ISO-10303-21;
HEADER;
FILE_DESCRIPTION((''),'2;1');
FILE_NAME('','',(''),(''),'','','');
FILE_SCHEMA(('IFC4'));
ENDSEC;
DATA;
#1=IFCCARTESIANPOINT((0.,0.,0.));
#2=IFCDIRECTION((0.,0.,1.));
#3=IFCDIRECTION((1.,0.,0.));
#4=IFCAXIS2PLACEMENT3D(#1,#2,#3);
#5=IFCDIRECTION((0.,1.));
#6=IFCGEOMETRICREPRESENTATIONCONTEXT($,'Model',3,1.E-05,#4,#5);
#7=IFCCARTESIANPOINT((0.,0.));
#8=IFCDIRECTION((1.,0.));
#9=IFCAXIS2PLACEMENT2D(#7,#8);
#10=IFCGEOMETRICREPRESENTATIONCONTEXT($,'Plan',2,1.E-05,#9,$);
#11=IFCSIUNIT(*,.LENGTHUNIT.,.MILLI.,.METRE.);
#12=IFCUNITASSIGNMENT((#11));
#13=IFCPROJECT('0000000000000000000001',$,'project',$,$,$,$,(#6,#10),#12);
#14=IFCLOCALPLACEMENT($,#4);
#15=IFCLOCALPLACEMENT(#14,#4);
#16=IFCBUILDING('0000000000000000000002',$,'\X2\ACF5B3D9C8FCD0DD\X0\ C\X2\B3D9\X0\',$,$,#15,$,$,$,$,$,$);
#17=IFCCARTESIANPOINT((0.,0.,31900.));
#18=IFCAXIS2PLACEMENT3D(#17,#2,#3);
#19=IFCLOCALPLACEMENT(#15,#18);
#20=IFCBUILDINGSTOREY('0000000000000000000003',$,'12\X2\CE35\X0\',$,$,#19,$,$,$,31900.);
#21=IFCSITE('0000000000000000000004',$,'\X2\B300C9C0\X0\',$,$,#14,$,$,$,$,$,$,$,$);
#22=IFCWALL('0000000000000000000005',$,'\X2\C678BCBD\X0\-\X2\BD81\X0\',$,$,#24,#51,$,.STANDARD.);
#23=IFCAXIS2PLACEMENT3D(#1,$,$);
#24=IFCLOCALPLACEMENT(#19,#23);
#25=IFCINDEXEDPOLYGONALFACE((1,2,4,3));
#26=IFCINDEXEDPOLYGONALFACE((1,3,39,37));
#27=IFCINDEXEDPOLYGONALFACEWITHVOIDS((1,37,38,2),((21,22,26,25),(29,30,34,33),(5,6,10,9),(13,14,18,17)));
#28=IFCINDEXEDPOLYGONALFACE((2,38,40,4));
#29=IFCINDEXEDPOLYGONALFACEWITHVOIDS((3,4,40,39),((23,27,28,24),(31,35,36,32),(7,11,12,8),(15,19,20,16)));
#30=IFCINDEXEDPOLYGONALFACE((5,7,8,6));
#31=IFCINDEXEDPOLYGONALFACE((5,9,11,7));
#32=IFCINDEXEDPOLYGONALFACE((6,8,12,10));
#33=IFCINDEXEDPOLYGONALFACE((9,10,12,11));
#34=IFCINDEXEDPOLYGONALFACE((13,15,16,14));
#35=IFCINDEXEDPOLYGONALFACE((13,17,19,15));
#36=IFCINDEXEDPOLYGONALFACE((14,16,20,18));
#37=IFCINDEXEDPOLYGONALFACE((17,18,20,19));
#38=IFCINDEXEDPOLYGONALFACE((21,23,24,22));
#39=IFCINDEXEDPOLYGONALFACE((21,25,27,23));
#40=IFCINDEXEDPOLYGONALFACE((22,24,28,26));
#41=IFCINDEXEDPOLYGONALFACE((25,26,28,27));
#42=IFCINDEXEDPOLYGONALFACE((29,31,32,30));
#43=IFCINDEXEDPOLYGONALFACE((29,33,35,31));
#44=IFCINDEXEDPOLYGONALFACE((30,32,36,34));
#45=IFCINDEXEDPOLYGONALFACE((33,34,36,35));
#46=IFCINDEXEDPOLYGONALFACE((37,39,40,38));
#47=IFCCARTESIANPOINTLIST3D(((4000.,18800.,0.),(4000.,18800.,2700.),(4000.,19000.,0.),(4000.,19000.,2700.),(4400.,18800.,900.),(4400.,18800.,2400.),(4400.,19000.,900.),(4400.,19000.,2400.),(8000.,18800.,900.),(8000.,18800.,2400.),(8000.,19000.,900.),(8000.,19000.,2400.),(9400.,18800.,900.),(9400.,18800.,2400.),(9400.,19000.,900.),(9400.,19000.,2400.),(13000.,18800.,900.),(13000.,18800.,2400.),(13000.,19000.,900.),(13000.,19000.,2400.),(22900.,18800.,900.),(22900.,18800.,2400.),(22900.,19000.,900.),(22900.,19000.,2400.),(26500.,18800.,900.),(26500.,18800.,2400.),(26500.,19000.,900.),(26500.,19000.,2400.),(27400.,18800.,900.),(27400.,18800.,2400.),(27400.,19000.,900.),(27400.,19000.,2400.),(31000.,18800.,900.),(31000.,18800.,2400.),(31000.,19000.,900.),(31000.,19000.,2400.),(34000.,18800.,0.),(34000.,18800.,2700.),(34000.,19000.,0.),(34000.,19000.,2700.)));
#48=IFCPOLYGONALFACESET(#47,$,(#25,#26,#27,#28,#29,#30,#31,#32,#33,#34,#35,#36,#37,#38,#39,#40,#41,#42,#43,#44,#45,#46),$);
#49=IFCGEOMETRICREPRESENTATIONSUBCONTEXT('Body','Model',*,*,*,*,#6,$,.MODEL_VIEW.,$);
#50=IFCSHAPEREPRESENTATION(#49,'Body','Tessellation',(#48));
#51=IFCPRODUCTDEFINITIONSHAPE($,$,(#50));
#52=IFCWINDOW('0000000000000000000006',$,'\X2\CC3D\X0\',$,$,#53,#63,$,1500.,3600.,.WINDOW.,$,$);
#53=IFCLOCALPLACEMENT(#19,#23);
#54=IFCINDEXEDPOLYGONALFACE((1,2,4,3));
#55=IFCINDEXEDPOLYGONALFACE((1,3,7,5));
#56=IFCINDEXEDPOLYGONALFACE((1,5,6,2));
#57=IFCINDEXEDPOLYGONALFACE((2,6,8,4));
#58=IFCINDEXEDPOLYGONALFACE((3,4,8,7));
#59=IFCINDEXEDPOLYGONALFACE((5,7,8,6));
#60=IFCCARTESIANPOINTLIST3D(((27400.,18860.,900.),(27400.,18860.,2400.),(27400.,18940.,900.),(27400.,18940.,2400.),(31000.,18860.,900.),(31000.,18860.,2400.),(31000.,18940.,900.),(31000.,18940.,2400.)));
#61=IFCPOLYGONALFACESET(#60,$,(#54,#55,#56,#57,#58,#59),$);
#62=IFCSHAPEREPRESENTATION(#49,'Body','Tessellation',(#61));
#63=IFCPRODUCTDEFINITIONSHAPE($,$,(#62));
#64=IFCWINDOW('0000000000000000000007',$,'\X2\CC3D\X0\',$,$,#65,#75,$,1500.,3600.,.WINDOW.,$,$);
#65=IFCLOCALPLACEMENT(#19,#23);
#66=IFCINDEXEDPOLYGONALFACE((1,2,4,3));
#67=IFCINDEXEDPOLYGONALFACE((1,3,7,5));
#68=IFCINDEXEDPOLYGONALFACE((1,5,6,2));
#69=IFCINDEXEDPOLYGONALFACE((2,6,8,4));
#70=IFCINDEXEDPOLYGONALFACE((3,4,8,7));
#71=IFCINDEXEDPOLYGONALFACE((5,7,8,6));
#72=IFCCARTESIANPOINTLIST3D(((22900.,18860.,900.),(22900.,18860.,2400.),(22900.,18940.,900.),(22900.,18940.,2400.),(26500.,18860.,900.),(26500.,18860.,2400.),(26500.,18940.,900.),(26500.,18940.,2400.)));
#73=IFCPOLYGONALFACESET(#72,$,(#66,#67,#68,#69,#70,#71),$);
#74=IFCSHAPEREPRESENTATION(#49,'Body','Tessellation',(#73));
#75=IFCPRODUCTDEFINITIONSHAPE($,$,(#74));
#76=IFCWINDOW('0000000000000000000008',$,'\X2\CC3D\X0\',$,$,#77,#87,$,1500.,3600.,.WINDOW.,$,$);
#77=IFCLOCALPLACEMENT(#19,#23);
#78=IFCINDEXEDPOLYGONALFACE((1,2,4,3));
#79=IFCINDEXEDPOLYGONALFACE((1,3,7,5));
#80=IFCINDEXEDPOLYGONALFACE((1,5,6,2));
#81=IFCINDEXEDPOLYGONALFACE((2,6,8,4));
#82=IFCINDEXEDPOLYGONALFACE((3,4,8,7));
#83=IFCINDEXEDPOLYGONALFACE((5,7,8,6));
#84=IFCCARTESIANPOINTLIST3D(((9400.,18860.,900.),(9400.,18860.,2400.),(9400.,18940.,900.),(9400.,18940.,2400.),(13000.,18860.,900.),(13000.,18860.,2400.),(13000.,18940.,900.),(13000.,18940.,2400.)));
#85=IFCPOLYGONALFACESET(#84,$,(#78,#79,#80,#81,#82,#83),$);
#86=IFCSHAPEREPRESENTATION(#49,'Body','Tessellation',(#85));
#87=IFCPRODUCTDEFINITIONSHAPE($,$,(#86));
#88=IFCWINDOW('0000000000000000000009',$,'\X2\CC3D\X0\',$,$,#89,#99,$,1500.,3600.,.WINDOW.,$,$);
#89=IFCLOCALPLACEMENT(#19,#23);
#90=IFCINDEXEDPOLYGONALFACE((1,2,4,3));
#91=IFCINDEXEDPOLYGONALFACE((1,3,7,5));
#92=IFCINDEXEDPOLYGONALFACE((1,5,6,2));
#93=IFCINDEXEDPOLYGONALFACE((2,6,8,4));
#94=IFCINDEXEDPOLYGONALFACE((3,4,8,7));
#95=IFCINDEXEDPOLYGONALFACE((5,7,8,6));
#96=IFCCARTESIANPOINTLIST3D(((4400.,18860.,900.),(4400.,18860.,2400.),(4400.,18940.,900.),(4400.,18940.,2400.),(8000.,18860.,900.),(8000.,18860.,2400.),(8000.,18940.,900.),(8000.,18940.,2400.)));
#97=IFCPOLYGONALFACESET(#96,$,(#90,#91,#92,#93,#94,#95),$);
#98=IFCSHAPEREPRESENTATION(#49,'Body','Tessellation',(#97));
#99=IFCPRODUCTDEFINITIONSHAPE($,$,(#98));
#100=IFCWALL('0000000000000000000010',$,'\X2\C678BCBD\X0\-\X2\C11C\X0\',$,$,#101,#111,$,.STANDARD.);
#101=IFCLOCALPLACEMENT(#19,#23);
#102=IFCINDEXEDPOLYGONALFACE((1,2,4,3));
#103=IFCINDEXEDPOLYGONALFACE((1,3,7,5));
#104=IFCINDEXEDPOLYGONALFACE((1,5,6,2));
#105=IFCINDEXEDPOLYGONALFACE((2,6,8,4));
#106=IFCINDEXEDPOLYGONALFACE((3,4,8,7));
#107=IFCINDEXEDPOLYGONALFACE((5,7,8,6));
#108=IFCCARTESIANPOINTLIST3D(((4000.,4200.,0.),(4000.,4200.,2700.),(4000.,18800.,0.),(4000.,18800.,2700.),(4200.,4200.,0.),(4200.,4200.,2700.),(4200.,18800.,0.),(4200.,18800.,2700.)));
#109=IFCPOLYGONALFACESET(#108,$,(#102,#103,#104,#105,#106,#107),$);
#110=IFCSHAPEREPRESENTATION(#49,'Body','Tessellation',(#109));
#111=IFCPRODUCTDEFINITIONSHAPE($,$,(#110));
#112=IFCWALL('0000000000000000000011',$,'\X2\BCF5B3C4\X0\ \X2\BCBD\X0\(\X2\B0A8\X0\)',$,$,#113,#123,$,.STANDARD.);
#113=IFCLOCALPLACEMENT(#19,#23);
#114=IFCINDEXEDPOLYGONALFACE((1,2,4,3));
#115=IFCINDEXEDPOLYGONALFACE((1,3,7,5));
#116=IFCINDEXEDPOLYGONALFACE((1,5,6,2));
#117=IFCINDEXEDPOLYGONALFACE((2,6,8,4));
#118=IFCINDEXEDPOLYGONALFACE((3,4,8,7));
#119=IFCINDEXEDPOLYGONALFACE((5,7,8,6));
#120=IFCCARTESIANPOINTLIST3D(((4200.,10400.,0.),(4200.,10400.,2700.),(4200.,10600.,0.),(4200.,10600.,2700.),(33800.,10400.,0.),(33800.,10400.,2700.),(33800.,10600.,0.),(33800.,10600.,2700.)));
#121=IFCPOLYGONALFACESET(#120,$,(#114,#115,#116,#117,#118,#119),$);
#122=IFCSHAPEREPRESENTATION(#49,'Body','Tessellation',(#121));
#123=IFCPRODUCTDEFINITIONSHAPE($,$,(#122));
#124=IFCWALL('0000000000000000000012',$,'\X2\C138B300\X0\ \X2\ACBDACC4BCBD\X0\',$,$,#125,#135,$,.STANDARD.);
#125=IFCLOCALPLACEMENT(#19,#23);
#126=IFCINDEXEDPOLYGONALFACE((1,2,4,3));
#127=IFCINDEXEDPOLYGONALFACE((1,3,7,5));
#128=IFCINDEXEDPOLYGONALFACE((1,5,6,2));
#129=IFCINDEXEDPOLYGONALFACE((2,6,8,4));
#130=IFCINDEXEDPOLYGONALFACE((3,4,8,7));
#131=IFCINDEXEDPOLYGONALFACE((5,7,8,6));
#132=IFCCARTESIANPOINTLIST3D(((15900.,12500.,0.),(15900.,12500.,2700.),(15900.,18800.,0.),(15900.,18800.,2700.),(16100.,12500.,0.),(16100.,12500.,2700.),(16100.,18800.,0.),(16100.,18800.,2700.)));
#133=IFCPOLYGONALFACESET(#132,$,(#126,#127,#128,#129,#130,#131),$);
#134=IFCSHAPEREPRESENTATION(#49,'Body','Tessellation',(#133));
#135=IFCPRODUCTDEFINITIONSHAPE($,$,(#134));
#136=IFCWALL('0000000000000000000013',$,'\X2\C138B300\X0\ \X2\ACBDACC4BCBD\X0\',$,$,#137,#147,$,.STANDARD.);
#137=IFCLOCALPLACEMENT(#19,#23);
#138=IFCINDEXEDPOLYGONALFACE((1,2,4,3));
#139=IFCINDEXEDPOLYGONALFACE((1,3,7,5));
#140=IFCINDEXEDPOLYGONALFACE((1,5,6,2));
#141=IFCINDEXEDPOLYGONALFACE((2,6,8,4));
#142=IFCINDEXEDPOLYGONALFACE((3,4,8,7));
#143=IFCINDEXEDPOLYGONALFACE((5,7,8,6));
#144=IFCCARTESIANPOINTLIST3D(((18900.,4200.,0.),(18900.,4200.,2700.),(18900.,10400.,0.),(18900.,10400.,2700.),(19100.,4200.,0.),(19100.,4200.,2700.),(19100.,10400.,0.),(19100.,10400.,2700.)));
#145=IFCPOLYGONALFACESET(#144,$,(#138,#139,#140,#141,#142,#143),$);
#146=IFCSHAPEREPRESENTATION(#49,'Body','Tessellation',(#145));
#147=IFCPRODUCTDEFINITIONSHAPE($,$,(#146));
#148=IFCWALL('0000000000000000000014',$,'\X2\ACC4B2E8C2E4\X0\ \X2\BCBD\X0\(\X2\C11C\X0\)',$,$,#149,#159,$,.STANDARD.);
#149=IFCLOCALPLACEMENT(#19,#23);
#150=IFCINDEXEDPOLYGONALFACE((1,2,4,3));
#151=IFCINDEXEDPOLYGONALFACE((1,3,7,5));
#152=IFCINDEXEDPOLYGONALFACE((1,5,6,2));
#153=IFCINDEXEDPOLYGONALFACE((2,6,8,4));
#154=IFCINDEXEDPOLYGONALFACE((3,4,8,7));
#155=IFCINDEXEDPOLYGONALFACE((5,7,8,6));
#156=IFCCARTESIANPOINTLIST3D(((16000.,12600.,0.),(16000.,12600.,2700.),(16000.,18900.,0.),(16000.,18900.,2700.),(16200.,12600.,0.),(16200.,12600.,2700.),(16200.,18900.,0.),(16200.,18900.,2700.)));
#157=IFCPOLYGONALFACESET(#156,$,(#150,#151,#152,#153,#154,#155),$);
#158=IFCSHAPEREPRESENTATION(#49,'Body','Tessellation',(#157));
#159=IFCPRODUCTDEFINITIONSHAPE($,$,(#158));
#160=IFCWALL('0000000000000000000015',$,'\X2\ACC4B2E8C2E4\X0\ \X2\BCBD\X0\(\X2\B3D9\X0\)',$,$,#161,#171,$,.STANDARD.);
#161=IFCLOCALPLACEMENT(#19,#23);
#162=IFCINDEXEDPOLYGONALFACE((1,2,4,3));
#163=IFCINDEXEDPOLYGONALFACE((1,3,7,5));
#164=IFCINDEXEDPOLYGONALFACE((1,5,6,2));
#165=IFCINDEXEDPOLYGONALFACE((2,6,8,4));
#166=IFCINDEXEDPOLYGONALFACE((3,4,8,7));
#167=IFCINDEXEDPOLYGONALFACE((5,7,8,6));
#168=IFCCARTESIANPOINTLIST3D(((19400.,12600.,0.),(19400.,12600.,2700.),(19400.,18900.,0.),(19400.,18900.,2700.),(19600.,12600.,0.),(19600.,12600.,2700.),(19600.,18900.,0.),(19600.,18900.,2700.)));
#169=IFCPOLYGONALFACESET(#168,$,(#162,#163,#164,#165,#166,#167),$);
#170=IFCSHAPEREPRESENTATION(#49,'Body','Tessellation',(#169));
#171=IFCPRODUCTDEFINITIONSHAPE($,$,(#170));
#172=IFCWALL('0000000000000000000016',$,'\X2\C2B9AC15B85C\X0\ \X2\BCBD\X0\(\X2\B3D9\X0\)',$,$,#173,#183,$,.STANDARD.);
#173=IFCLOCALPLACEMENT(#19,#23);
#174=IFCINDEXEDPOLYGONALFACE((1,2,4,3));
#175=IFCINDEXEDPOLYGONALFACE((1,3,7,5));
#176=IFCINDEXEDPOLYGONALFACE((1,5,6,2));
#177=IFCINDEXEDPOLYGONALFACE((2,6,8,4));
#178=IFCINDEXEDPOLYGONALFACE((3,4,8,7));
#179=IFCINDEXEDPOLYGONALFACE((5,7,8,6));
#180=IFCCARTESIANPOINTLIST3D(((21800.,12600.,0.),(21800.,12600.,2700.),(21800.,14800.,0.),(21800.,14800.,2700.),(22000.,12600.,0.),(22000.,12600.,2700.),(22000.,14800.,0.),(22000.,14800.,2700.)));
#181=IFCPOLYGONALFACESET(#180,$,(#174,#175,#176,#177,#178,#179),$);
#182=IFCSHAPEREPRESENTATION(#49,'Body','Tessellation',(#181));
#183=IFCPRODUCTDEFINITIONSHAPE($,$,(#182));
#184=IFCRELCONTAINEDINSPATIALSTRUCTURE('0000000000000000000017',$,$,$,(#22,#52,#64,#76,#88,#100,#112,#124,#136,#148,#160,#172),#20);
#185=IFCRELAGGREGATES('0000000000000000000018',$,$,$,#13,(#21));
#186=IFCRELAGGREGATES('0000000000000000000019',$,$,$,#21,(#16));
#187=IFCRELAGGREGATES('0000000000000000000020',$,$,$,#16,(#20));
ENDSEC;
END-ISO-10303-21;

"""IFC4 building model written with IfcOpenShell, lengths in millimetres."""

from ifc_helpers import new_model, si_unit, direction, frame, origin_with_axes, origin_2d_with_axis, place, context, subcontext, project, spatial, polyline, outline, extrude, element, fill, save


model = new_model("IFC4")

# Units and contexts
model_context = context("Model", 3, precision=1e-05, world=origin_with_axes(), true_north=direction((0.0, 1.0)))
plan_context = context("Plan", 2, precision=1e-05, world=origin_2d_with_axis())
body_context = subcontext(model_context, "Body", "Model", "MODEL_VIEW")
ifc_project = project(units=[si_unit("LENGTHUNIT", "METRE", prefix="MILLI")], contexts=[model_context, plan_context])

# Site, building, storey
site_placement = place(None, origin_with_axes())
site = spatial("IfcSite", under=ifc_project, at=site_placement, Name="대지")
building_placement = place(site_placement, origin_with_axes())
building = spatial("IfcBuilding", under=site, at=building_placement, Name="공동주택 C동")
storey_placement = place(building_placement, frame((0.0, 0.0, 31900.0), z_axis=(0.0, 0.0, 1.0), x_axis=(1.0, 0.0, 0.0)))
storey = spatial("IfcBuildingStorey", under=building, at=storey_placement, Name="12층", Elevation=31900.0)

# Wall, openings, windows
wall_1_placement = place(storey_placement, origin_with_axes())
wall_1 = element("IfcWall", 1, at=wall_1_placement, inside=storey, Name="외벽-북", PredefinedType="STANDARD", context=body_context, shape_type="SweptSolid", body=[
    extrude(outline(polyline([(34000.0, 18800.0), (4000.0, 18800.0), (4000.0, 19000.0), (34000.0, 19000.0), (34000.0, 18800.0)])), origin_with_axes(), (0.0, 0.0, 1.0), 2700.0),
])
opening_1_placement = place(storey_placement, origin_with_axes())
opening_1 = element("IfcOpeningElement", 2, at=opening_1_placement, cuts=wall_1, PredefinedType="OPENING", context=body_context, shape_type="SweptSolid", body=[
    extrude(outline(polyline([(31000.0, 19050.0), (27400.0, 19050.0), (27400.0, 18750.0), (31000.0, 18750.0), (31000.0, 19050.0)])), frame((0.0, 0.0, 900.0), z_axis=(0.0, 0.0, 1.0), x_axis=(1.0, 0.0, 0.0)), (0.0, 0.0, 1.0), 1500.0),
])
opening_2_placement = place(storey_placement, origin_with_axes())
opening_2 = element("IfcOpeningElement", 3, at=opening_2_placement, cuts=wall_1, PredefinedType="OPENING", context=body_context, shape_type="SweptSolid", body=[
    extrude(outline(polyline([(26500.0, 19050.0), (22900.0, 19050.0), (22900.0, 18750.0), (26500.0, 18750.0), (26500.0, 19050.0)])), frame((0.0, 0.0, 900.0), z_axis=(0.0, 0.0, 1.0), x_axis=(1.0, 0.0, 0.0)), (0.0, 0.0, 1.0), 1500.0),
])
opening_3_placement = place(storey_placement, origin_with_axes())
opening_3 = element("IfcOpeningElement", 4, at=opening_3_placement, cuts=wall_1, PredefinedType="OPENING", context=body_context, shape_type="SweptSolid", body=[
    extrude(outline(polyline([(13000.0, 19050.0), (9400.0, 19050.0), (9400.0, 18750.0), (13000.0, 18750.0), (13000.0, 19050.0)])), frame((0.0, 0.0, 900.0), z_axis=(0.0, 0.0, 1.0), x_axis=(1.0, 0.0, 0.0)), (0.0, 0.0, 1.0), 1500.0),
])
opening_4_placement = place(storey_placement, origin_with_axes())
opening_4 = element("IfcOpeningElement", 5, at=opening_4_placement, cuts=wall_1, PredefinedType="OPENING", context=body_context, shape_type="SweptSolid", body=[
    extrude(outline(polyline([(8000.0, 19050.0), (4400.0, 19050.0), (4400.0, 18750.0), (8000.0, 18750.0), (8000.0, 19050.0)])), frame((0.0, 0.0, 900.0), z_axis=(0.0, 0.0, 1.0), x_axis=(1.0, 0.0, 0.0)), (0.0, 0.0, 1.0), 1500.0),
])
window_1_placement = place(storey_placement, origin_with_axes())
window_1 = element("IfcWindow", 6, at=window_1_placement, inside=storey, Name="창", OverallHeight=1500.0, OverallWidth=3600.0, PredefinedType="WINDOW", context=body_context, shape_type="SweptSolid", body=[
    extrude(outline(polyline([(31000.0, 18940.0), (27400.0, 18940.0), (27400.0, 18860.0), (31000.0, 18860.0), (31000.0, 18940.0)])), frame((0.0, 0.0, 900.0), z_axis=(0.0, 0.0, 1.0), x_axis=(1.0, 0.0, 0.0)), (0.0, 0.0, 1.0), 1500.0),
])
fill(opening_1, window_1)
window_2_placement = place(storey_placement, origin_with_axes())
window_2 = element("IfcWindow", 7, at=window_2_placement, inside=storey, Name="창", OverallHeight=1500.0, OverallWidth=3600.0, PredefinedType="WINDOW", context=body_context, shape_type="SweptSolid", body=[
    extrude(outline(polyline([(26500.0, 18940.0), (22900.0, 18940.0), (22900.0, 18860.0), (26500.0, 18860.0), (26500.0, 18940.0)])), frame((0.0, 0.0, 900.0), z_axis=(0.0, 0.0, 1.0), x_axis=(1.0, 0.0, 0.0)), (0.0, 0.0, 1.0), 1500.0),
])
fill(opening_2, window_2)
window_3_placement = place(storey_placement, origin_with_axes())
window_3 = element("IfcWindow", 8, at=window_3_placement, inside=storey, Name="창", OverallHeight=1500.0, OverallWidth=3600.0, PredefinedType="WINDOW", context=body_context, shape_type="SweptSolid", body=[
    extrude(outline(polyline([(13000.0, 18940.0), (9400.0, 18940.0), (9400.0, 18860.0), (13000.0, 18860.0), (13000.0, 18940.0)])), frame((0.0, 0.0, 900.0), z_axis=(0.0, 0.0, 1.0), x_axis=(1.0, 0.0, 0.0)), (0.0, 0.0, 1.0), 1500.0),
])
fill(opening_3, window_3)
window_4_placement = place(storey_placement, origin_with_axes())
window_4 = element("IfcWindow", 9, at=window_4_placement, inside=storey, Name="창", OverallHeight=1500.0, OverallWidth=3600.0, PredefinedType="WINDOW", context=body_context, shape_type="SweptSolid", body=[
    extrude(outline(polyline([(8000.0, 18940.0), (4400.0, 18940.0), (4400.0, 18860.0), (8000.0, 18860.0), (8000.0, 18940.0)])), frame((0.0, 0.0, 900.0), z_axis=(0.0, 0.0, 1.0), x_axis=(1.0, 0.0, 0.0)), (0.0, 0.0, 1.0), 1500.0),
])
fill(opening_4, window_4)

# Walls
wall_2_placement = place(storey_placement, origin_with_axes())
element("IfcWall", 10, at=wall_2_placement, inside=storey, Name="외벽-서", PredefinedType="STANDARD", context=body_context, shape_type="SweptSolid", body=[
    extrude(outline(polyline([(4200.0, 18800.0), (4200.0, 4200.0), (4000.0, 4200.0), (4000.0, 18800.0), (4200.0, 18800.0)])), origin_with_axes(), (0.0, 0.0, 1.0), 2700.0),
])
wall_3_placement = place(storey_placement, origin_with_axes())
element("IfcWall", 11, at=wall_3_placement, inside=storey, Name="복도 벽(남)", PredefinedType="STANDARD", context=body_context, shape_type="SweptSolid", body=[
    extrude(outline(polyline([(4200.0, 10600.0), (33800.0, 10600.0), (33800.0, 10400.0), (4200.0, 10400.0), (4200.0, 10600.0)])), origin_with_axes(), (0.0, 0.0, 1.0), 2700.0),
])
wall_4_placement = place(storey_placement, origin_with_axes())
element("IfcWall", 12, at=wall_4_placement, inside=storey, Name="세대 경계벽", PredefinedType="STANDARD", context=body_context, shape_type="SweptSolid", body=[
    extrude(outline(polyline([(15900.0, 12500.0), (15900.0, 18800.0), (16100.0, 18800.0), (16100.0, 12500.0), (15900.0, 12500.0)])), origin_with_axes(), (0.0, 0.0, 1.0), 2700.0),
])
wall_5_placement = place(storey_placement, origin_with_axes())
element("IfcWall", 13, at=wall_5_placement, inside=storey, Name="세대 경계벽", PredefinedType="STANDARD", context=body_context, shape_type="SweptSolid", body=[
    extrude(outline(polyline([(18900.0, 4200.0), (18900.0, 10400.0), (19100.0, 10400.0), (19100.0, 4200.0), (18900.0, 4200.0)])), origin_with_axes(), (0.0, 0.0, 1.0), 2700.0),
])
wall_6_placement = place(storey_placement, origin_with_axes())
element("IfcWall", 14, at=wall_6_placement, inside=storey, Name="계단실 벽(서)", PredefinedType="STANDARD", context=body_context, shape_type="SweptSolid", body=[
    extrude(outline(polyline([(16000.0, 12600.0), (16000.0, 18900.0), (16200.0, 18900.0), (16200.0, 12600.0), (16000.0, 12600.0)])), origin_with_axes(), (0.0, 0.0, 1.0), 2700.0),
])
wall_7_placement = place(storey_placement, origin_with_axes())
element("IfcWall", 15, at=wall_7_placement, inside=storey, Name="계단실 벽(동)", PredefinedType="STANDARD", context=body_context, shape_type="SweptSolid", body=[
    extrude(outline(polyline([(19400.0, 12600.0), (19400.0, 18900.0), (19600.0, 18900.0), (19600.0, 12600.0), (19400.0, 12600.0)])), origin_with_axes(), (0.0, 0.0, 1.0), 2700.0),
])
wall_8_placement = place(storey_placement, origin_with_axes())
element("IfcWall", 16, at=wall_8_placement, inside=storey, Name="승강로 벽(동)", PredefinedType="STANDARD", context=body_context, shape_type="SweptSolid", body=[
    extrude(outline(polyline([(21800.0, 12600.0), (21800.0, 14800.0), (22000.0, 14800.0), (22000.0, 12600.0), (21800.0, 12600.0)])), origin_with_axes(), (0.0, 0.0, 1.0), 2700.0),
])

save(model, "model.ifc")
